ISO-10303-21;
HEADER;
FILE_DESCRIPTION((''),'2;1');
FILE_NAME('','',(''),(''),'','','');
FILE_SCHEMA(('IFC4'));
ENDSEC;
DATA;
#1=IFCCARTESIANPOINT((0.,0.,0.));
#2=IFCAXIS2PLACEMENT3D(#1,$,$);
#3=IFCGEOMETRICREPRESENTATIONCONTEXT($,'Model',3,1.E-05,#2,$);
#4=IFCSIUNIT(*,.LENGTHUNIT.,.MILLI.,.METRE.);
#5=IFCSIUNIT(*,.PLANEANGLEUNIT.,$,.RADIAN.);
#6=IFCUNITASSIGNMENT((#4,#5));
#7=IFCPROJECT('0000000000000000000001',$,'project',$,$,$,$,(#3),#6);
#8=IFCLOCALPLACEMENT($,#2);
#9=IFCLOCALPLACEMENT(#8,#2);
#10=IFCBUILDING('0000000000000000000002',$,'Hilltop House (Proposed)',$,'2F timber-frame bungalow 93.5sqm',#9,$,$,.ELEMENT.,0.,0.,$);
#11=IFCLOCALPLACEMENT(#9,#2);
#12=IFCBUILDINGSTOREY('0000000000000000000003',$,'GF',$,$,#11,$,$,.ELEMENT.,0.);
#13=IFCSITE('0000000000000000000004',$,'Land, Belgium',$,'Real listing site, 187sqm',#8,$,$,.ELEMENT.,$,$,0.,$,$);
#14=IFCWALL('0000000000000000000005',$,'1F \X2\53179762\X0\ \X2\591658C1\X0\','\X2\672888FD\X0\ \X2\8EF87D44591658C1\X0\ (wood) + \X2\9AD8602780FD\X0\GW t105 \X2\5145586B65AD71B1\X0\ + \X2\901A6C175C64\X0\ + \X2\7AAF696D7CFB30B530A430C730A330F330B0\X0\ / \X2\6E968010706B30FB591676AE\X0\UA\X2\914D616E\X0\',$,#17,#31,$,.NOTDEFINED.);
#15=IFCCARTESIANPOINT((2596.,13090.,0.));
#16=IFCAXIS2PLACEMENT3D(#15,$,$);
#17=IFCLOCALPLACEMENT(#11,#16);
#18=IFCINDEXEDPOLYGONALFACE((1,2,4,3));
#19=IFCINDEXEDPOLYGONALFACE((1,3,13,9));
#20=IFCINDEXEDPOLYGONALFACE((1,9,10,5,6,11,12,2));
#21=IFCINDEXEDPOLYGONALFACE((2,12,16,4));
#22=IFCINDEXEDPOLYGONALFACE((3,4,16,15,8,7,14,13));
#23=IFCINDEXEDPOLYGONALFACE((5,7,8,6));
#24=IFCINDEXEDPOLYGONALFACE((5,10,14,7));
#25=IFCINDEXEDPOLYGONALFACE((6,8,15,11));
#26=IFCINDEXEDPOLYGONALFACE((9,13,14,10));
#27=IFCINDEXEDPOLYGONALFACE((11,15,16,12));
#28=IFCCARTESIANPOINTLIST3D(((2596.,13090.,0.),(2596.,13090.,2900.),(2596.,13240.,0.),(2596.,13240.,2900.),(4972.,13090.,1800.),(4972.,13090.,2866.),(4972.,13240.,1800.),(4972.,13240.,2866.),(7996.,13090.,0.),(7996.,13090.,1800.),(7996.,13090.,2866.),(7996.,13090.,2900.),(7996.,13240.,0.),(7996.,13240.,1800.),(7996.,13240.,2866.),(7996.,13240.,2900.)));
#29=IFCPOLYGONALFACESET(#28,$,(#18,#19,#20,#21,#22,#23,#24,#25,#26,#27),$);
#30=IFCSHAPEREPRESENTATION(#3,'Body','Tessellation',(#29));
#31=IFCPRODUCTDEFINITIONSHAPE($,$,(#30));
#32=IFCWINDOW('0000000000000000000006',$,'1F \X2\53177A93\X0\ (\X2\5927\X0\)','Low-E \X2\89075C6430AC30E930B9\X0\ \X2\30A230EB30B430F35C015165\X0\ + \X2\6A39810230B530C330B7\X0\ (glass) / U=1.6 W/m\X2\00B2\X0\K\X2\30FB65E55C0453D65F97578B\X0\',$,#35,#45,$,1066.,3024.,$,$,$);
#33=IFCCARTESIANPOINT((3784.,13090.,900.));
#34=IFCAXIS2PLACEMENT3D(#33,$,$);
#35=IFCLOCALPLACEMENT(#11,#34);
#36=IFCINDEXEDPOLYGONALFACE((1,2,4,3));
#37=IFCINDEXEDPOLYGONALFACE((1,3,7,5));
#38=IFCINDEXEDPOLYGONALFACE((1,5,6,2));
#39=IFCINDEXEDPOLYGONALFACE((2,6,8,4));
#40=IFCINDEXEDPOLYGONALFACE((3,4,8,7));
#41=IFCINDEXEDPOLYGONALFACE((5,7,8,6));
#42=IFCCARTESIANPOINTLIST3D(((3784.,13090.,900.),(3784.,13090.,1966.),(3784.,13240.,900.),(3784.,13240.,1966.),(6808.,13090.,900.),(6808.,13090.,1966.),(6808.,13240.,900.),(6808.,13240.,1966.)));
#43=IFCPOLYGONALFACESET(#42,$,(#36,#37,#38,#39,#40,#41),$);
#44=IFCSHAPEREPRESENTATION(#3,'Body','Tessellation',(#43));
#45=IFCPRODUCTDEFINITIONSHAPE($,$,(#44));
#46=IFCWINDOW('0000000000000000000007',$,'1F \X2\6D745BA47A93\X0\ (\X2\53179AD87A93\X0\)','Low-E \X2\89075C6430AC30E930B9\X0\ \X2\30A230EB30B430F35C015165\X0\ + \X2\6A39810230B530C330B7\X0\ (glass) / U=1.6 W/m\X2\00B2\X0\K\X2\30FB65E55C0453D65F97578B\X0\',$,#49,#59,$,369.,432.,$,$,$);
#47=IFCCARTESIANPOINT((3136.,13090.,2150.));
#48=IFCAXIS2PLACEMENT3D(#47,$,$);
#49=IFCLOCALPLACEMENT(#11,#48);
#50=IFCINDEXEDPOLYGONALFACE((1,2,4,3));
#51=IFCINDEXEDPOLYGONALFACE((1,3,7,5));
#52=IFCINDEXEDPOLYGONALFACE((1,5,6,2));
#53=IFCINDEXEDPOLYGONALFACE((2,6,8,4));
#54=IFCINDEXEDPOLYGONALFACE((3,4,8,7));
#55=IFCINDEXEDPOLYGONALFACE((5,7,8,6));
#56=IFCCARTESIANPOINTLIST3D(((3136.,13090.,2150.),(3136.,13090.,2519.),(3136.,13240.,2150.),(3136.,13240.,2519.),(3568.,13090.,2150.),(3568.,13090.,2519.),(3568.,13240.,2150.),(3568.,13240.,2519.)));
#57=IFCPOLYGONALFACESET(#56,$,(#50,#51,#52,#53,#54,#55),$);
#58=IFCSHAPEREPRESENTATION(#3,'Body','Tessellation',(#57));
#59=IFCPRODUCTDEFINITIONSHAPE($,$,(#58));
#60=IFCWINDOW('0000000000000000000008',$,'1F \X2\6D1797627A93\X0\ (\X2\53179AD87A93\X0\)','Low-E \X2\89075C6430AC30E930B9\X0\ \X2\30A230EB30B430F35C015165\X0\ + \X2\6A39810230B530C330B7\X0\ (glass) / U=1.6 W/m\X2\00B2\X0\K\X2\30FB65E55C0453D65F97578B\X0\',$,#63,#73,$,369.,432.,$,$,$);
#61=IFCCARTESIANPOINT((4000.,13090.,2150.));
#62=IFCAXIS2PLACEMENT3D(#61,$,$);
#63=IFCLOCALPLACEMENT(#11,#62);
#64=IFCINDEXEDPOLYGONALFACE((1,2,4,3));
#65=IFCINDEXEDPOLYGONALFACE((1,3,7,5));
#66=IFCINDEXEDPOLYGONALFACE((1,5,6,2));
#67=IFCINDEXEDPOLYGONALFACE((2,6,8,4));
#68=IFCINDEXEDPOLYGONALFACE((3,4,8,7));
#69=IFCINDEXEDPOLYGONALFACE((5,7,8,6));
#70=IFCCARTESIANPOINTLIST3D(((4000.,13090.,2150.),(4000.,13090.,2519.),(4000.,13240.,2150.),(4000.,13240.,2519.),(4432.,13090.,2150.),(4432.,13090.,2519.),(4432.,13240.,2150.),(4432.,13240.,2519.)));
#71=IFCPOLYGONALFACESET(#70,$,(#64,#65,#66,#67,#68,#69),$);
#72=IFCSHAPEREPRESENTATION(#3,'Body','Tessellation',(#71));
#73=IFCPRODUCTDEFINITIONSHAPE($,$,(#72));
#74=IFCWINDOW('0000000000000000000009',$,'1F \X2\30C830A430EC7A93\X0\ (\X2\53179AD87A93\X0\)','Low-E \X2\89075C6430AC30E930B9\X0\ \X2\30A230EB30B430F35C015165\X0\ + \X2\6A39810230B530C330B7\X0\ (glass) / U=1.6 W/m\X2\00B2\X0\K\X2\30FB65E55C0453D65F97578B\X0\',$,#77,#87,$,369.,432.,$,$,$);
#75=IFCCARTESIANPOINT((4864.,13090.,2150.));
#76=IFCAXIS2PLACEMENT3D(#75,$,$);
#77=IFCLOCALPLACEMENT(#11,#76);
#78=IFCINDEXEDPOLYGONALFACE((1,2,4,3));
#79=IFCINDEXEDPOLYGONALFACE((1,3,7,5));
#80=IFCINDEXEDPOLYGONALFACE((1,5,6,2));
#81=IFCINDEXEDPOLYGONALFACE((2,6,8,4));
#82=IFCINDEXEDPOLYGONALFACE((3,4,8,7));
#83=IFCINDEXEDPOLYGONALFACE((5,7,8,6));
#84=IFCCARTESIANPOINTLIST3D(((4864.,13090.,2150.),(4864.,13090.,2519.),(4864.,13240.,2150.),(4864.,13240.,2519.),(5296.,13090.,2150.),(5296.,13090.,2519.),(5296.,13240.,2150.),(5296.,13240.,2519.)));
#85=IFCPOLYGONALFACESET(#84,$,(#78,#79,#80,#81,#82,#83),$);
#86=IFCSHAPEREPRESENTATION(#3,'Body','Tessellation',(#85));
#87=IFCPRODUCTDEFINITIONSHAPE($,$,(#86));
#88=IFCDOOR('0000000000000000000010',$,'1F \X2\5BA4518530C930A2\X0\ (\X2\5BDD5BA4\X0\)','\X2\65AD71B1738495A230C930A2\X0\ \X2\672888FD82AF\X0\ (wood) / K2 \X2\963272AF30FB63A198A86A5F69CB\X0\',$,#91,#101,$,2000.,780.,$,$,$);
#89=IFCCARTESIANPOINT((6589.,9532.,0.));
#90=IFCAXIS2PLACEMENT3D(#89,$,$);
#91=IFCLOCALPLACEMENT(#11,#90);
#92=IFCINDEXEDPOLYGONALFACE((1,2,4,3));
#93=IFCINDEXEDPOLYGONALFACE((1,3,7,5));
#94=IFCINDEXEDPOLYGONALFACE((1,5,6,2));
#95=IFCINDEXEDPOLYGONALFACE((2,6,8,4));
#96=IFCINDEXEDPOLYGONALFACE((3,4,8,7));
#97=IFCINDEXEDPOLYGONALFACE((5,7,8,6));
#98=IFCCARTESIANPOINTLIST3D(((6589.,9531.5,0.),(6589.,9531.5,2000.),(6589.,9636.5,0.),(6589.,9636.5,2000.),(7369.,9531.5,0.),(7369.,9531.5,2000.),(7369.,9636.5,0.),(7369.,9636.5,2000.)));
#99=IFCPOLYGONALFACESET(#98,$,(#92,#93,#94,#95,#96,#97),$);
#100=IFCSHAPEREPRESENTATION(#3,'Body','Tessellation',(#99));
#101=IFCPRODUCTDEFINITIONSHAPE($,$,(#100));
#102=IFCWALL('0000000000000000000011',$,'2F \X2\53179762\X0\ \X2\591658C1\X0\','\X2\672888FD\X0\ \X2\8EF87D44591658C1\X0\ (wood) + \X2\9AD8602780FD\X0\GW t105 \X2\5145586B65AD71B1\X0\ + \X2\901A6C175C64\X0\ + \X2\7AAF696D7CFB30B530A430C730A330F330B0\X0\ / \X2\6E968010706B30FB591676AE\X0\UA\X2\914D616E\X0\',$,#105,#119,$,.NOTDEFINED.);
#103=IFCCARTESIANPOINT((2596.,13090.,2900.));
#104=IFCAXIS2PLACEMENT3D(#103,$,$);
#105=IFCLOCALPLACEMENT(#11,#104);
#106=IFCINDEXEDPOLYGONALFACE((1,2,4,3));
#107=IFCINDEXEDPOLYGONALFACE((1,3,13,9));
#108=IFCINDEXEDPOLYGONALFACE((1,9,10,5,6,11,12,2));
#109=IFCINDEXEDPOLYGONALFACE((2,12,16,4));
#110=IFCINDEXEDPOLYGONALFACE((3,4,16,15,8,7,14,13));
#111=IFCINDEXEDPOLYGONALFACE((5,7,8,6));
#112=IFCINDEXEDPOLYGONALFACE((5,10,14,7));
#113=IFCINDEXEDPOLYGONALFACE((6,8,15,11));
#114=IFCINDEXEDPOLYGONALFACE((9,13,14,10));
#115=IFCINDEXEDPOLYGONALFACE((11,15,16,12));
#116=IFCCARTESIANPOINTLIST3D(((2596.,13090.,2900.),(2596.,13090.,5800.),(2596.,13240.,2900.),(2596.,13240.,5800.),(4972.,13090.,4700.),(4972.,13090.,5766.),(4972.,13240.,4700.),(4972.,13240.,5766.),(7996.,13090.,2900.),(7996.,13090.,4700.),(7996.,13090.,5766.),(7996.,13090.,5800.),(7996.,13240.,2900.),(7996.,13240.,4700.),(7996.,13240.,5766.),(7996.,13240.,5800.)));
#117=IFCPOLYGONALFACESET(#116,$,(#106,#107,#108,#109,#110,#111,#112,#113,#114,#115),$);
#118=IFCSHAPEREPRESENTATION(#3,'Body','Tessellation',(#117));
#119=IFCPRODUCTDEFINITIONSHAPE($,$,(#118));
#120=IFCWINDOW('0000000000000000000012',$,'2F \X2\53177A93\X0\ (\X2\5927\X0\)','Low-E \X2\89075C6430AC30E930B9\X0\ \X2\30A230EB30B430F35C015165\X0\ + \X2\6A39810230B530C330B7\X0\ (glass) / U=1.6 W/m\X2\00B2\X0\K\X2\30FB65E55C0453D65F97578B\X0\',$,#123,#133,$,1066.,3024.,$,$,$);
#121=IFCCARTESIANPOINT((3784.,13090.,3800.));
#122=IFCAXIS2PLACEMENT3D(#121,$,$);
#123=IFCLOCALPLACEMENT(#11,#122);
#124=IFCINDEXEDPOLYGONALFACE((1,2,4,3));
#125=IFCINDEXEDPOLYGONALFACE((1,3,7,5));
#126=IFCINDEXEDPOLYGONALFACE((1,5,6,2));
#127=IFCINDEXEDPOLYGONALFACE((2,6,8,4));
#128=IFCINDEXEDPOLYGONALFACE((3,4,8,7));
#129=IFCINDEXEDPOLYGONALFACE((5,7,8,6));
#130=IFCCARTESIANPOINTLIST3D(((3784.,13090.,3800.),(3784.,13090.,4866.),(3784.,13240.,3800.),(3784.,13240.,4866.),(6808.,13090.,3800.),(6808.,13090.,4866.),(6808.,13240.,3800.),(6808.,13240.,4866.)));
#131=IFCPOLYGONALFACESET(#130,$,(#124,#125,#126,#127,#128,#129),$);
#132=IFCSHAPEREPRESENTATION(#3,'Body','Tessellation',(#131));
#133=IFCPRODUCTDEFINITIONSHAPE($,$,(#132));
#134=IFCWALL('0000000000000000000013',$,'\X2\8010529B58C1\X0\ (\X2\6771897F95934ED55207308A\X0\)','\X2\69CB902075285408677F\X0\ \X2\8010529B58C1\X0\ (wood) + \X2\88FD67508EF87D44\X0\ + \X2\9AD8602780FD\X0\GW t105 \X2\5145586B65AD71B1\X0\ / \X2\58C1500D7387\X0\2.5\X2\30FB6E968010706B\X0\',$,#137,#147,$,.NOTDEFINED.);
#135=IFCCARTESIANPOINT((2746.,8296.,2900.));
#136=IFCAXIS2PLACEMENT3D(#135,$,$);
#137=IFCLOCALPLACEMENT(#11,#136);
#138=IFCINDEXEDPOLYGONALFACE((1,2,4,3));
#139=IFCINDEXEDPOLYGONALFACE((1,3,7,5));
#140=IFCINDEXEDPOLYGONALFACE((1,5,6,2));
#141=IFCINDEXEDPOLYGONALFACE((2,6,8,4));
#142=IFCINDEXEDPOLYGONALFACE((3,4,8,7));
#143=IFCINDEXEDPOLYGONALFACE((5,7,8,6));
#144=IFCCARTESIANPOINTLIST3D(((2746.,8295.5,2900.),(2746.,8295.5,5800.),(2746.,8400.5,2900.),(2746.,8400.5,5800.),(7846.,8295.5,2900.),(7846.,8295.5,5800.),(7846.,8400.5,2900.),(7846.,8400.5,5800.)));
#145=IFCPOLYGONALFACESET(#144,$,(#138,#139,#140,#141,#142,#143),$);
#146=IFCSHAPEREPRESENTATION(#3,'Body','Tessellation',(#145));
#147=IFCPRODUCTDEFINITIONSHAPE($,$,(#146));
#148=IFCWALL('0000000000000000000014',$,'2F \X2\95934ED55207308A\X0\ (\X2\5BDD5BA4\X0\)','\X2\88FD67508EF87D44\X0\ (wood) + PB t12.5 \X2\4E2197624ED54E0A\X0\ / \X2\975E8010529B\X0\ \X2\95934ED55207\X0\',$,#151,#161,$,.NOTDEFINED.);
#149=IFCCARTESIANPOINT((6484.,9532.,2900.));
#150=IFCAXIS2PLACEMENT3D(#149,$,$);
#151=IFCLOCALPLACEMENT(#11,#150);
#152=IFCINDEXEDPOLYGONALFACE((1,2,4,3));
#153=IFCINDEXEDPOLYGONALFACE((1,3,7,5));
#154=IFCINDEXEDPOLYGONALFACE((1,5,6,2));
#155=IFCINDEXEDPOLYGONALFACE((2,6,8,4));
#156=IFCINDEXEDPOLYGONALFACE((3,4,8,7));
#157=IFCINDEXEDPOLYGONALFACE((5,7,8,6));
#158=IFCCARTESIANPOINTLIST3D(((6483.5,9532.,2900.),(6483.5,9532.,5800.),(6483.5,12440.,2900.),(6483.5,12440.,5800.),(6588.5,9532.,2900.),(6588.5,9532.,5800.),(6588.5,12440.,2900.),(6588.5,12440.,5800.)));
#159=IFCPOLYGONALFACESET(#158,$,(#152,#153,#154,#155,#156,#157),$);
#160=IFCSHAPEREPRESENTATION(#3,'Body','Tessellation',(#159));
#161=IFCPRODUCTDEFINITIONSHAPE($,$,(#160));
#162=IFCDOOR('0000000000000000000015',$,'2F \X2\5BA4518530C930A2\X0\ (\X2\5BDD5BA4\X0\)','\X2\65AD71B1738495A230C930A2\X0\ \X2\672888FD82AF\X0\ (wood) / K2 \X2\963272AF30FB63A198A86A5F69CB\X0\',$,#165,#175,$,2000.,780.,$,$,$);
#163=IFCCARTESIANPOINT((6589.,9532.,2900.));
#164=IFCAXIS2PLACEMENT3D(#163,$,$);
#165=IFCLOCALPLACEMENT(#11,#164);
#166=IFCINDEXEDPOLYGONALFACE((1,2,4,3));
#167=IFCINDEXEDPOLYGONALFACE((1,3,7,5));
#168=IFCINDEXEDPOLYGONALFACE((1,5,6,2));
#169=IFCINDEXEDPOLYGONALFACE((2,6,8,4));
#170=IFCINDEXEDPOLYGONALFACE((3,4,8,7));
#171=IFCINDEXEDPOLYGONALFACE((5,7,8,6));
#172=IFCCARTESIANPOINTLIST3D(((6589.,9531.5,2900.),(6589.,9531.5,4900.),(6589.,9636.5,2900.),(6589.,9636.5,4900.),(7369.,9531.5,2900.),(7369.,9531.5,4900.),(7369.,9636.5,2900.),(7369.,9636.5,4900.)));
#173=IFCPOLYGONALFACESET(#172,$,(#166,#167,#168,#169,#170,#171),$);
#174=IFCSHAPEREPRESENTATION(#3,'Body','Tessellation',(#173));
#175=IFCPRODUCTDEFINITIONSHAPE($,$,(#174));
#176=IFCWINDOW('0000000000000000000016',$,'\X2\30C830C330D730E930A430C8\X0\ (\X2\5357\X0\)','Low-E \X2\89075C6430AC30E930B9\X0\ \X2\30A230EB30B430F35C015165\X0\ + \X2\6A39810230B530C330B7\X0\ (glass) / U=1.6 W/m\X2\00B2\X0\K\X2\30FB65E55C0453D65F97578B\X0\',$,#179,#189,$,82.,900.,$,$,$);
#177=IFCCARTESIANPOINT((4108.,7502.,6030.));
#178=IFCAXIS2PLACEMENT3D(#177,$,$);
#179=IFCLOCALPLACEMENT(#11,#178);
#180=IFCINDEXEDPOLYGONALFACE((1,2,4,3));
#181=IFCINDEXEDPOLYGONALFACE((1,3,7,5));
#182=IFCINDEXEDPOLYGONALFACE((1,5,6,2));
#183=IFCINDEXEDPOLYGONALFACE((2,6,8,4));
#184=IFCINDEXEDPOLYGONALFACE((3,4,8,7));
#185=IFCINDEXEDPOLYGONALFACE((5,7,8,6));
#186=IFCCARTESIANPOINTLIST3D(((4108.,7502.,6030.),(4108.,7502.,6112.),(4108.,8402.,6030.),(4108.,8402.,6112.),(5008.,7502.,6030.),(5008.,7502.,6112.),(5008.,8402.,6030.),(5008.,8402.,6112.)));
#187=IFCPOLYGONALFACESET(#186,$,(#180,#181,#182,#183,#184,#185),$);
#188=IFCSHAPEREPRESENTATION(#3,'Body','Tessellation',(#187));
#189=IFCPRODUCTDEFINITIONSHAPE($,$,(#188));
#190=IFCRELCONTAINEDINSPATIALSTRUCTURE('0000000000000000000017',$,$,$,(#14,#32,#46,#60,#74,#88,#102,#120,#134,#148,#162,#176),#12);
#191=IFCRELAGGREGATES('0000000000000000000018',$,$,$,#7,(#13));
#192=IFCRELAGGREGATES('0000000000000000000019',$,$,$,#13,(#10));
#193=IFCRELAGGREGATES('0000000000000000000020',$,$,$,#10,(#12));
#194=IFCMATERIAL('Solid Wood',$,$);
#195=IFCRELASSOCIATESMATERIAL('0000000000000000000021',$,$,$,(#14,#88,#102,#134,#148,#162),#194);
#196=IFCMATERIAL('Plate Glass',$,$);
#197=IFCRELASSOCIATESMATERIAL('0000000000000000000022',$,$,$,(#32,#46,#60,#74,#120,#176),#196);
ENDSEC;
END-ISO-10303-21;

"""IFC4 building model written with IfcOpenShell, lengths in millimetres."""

from ifc_helpers import new_model, si_unit, frame, frame_2d, origin, place, context, project, spatial, rectangle, extrude, material, element, fill, save


model = new_model("IFC4")

# Units and contexts
model_context = context("Model", 3, precision=1e-05, world=origin())
ifc_project = project(units=[si_unit("LENGTHUNIT", "METRE", prefix="MILLI"), si_unit("PLANEANGLEUNIT", "RADIAN")], contexts=[model_context])

# Site, building, storey
site_placement = place(None, origin())
site = spatial("IfcSite", under=ifc_project, at=site_placement, Name="Land, Belgium", ObjectType="Real listing site, 187sqm", CompositionType="ELEMENT", RefElevation=0.0)
building_placement = place(site_placement, origin())
building = spatial("IfcBuilding", under=site, at=building_placement, Name="Hilltop House (Proposed)", ObjectType="2F timber-frame bungalow 93.5sqm", CompositionType="ELEMENT", ElevationOfRefHeight=0.0, ElevationOfTerrain=0.0)
storey_placement = place(building_placement, origin())
storey = spatial("IfcBuildingStorey", under=building, at=storey_placement, Name="GF", CompositionType="ELEMENT", Elevation=0.0)

# Wall, openings, windows
ifc_material_1 = material(Name="Solid Wood")
wall_1_placement = place(storey_placement, frame((2596.0, 13090.0, 0.0)))
wall_1 = element("IfcWall", 1, at=wall_1_placement, inside=storey, material=ifc_material_1, Name="1F 北面 外壁", Description="木製 軸組外壁 (wood) + 高性能GW t105 充填断熱 + 通気層 + 窯業系サイディング / 準耐火・外皮UA配慮", PredefinedType="NOTDEFINED", context=model_context, shape_type="SweptSolid", body=[
    extrude(rectangle(XDim=5400.0, YDim=150.0, at=frame_2d((2700.0, 75.0))), frame((2596.0, 13090.0, 0.0)), (0.0, 0.0, 1.0), 2900.0),
])
opening_1_placement = place(storey_placement, frame((3784.0, 13090.0, 900.0)))
opening_1 = element("IfcOpeningElement", 2, at=opening_1_placement, cuts=wall_1, PredefinedType="NOTDEFINED", context=model_context, shape_type="SweptSolid", body=[
    extrude(rectangle(XDim=3024.0, YDim=150.0, at=frame_2d((1512.0, 75.0))), frame((3784.0, 13090.0, 900.0)), (0.0, 0.0, 1.0), 1066.0),
])
opening_2_placement = place(storey_placement, frame((3136.0, 13090.0, 2150.0)))
opening_2 = element("IfcOpeningElement", 3, at=opening_2_placement, cuts=wall_1, PredefinedType="NOTDEFINED", context=model_context, shape_type="SweptSolid", body=[
    extrude(rectangle(XDim=432.0, YDim=150.0, at=frame_2d((216.0, 75.0))), frame((3136.0, 13090.0, 2150.0)), (0.0, 0.0, 1.0), 369.0),
])
opening_3_placement = place(storey_placement, frame((4000.0, 13090.0, 2150.0)))
opening_3 = element("IfcOpeningElement", 4, at=opening_3_placement, cuts=wall_1, PredefinedType="NOTDEFINED", context=model_context, shape_type="SweptSolid", body=[
    extrude(rectangle(XDim=432.0, YDim=150.0, at=frame_2d((216.0, 75.0))), frame((4000.0, 13090.0, 2150.0)), (0.0, 0.0, 1.0), 369.0),
])
opening_4_placement = place(storey_placement, frame((4864.0, 13090.0, 2150.0)))
opening_4 = element("IfcOpeningElement", 5, at=opening_4_placement, cuts=wall_1, PredefinedType="NOTDEFINED", context=model_context, shape_type="SweptSolid", body=[
    extrude(rectangle(XDim=432.0, YDim=150.0, at=frame_2d((216.0, 75.0))), frame((4864.0, 13090.0, 2150.0)), (0.0, 0.0, 1.0), 369.0),
])
ifc_material_2 = material(Name="Plate Glass")
window_1_placement = place(storey_placement, frame((3784.0, 13090.0, 900.0)))
window_1 = element("IfcWindow", 6, at=window_1_placement, inside=storey, material=ifc_material_2, Name="1F 北窓 (大)", Description="Low-E 複層ガラス アルゴン封入 + 樹脂サッシ (glass) / U=1.6 W/m²K・日射取得型", OverallHeight=1066.0, OverallWidth=3024.0, context=model_context, shape_type="SweptSolid", body=[
    extrude(rectangle(XDim=3024.0, YDim=150.0, at=frame_2d((1512.0, 75.0))), frame((3784.0, 13090.0, 900.0)), (0.0, 0.0, 1.0), 1066.0),
])
fill(opening_1, window_1)
window_2_placement = place(storey_placement, frame((3136.0, 13090.0, 2150.0)))
window_2 = element("IfcWindow", 7, at=window_2_placement, inside=storey, material=ifc_material_2, Name="1F 浴室窓 (北高窓)", Description="Low-E 複層ガラス アルゴン封入 + 樹脂サッシ (glass) / U=1.6 W/m²K・日射取得型", OverallHeight=369.0, OverallWidth=432.0, context=model_context, shape_type="SweptSolid", body=[
    extrude(rectangle(XDim=432.0, YDim=150.0, at=frame_2d((216.0, 75.0))), frame((3136.0, 13090.0, 2150.0)), (0.0, 0.0, 1.0), 369.0),
])
fill(opening_2, window_2)
window_3_placement = place(storey_placement, frame((4000.0, 13090.0, 2150.0)))
window_3 = element("IfcWindow", 8, at=window_3_placement, inside=storey, material=ifc_material_2, Name="1F 洗面窓 (北高窓)", Description="Low-E 複層ガラス アルゴン封入 + 樹脂サッシ (glass) / U=1.6 W/m²K・日射取得型", OverallHeight=369.0, OverallWidth=432.0, context=model_context, shape_type="SweptSolid", body=[
    extrude(rectangle(XDim=432.0, YDim=150.0, at=frame_2d((216.0, 75.0))), frame((4000.0, 13090.0, 2150.0)), (0.0, 0.0, 1.0), 369.0),
])
fill(opening_3, window_3)
window_4_placement = place(storey_placement, frame((4864.0, 13090.0, 2150.0)))
window_4 = element("IfcWindow", 9, at=window_4_placement, inside=storey, material=ifc_material_2, Name="1F トイレ窓 (北高窓)", Description="Low-E 複層ガラス アルゴン封入 + 樹脂サッシ (glass) / U=1.6 W/m²K・日射取得型", OverallHeight=369.0, OverallWidth=432.0, context=model_context, shape_type="SweptSolid", body=[
    extrude(rectangle(XDim=432.0, YDim=150.0, at=frame_2d((216.0, 75.0))), frame((4864.0, 13090.0, 2150.0)), (0.0, 0.0, 1.0), 369.0),
])
fill(opening_4, window_4)

# Door
door_1_placement = place(storey_placement, frame((6589.0, 9532.0, 0.0)))
element("IfcDoor", 10, at=door_1_placement, inside=storey, material=ifc_material_1, Name="1F 室内ドア (寝室)", Description="断熱玄関ドア 木製芯 (wood) / K2 防犯・採風機構", OverallHeight=2000.0, OverallWidth=780.0, context=model_context, shape_type="SweptSolid", body=[
    extrude(rectangle(XDim=780.0, YDim=105.0, at=frame_2d((390.0, 52.0))), frame((6589.0, 9532.0, 0.0)), (0.0, 0.0, 1.0), 2000.0),
])

# Wall, opening, window
wall_2_placement = place(storey_placement, frame((2596.0, 13090.0, 2900.0)))
wall_2 = element("IfcWall", 11, at=wall_2_placement, inside=storey, material=ifc_material_1, Name="2F 北面 外壁", Description="木製 軸組外壁 (wood) + 高性能GW t105 充填断熱 + 通気層 + 窯業系サイディング / 準耐火・外皮UA配慮", PredefinedType="NOTDEFINED", context=model_context, shape_type="SweptSolid", body=[
    extrude(rectangle(XDim=5400.0, YDim=150.0, at=frame_2d((2700.0, 75.0))), frame((2596.0, 13090.0, 2900.0)), (0.0, 0.0, 1.0), 2900.0),
])
opening_5_placement = place(storey_placement, frame((3784.0, 13090.0, 3800.0)))
opening_5 = element("IfcOpeningElement", 12, at=opening_5_placement, cuts=wall_2, PredefinedType="NOTDEFINED", context=model_context, shape_type="SweptSolid", body=[
    extrude(rectangle(XDim=3024.0, YDim=150.0, at=frame_2d((1512.0, 75.0))), frame((3784.0, 13090.0, 3800.0)), (0.0, 0.0, 1.0), 1066.0),
])
window_5_placement = place(storey_placement, frame((3784.0, 13090.0, 3800.0)))
window_5 = element("IfcWindow", 13, at=window_5_placement, inside=storey, material=ifc_material_2, Name="2F 北窓 (大)", Description="Low-E 複層ガラス アルゴン封入 + 樹脂サッシ (glass) / U=1.6 W/m²K・日射取得型", OverallHeight=1066.0, OverallWidth=3024.0, context=model_context, shape_type="SweptSolid", body=[
    extrude(rectangle(XDim=3024.0, YDim=150.0, at=frame_2d((1512.0, 75.0))), frame((3784.0, 13090.0, 3800.0)), (0.0, 0.0, 1.0), 1066.0),
])
fill(opening_5, window_5)

# Walls
wall_3_placement = place(storey_placement, frame((2746.0, 8296.0, 2900.0)))
element("IfcWall", 14, at=wall_3_placement, inside=storey, material=ifc_material_1, Name="耐力壁 (東西間仕切り)", Description="構造用合板 耐力壁 (wood) + 製材軸組 + 高性能GW t105 充填断熱 / 壁倍率2.5・準耐火", PredefinedType="NOTDEFINED", context=model_context, shape_type="SweptSolid", body=[
    extrude(rectangle(XDim=5100.0, YDim=105.0, at=frame_2d((2550.0, 52.0))), frame((2746.0, 8296.0, 2900.0)), (0.0, 0.0, 1.0), 2900.0),
])
wall_4_placement = place(storey_placement, frame((6484.0, 9532.0, 2900.0)))
element("IfcWall", 15, at=wall_4_placement, inside=storey, material=ifc_material_1, Name="2F 間仕切り (寝室)", Description="製材軸組 (wood) + PB t12.5 両面仕上 / 非耐力 間仕切", PredefinedType="NOTDEFINED", context=model_context, shape_type="SweptSolid", body=[
    extrude(rectangle(XDim=105.0, YDim=2908.0, at=frame_2d((52.0, 1454.0))), frame((6484.0, 9532.0, 2900.0)), (0.0, 0.0, 1.0), 2900.0),
])

# Door
door_2_placement = place(storey_placement, frame((6589.0, 9532.0, 2900.0)))
element("IfcDoor", 16, at=door_2_placement, inside=storey, material=ifc_material_1, Name="2F 室内ドア (寝室)", Description="断熱玄関ドア 木製芯 (wood) / K2 防犯・採風機構", OverallHeight=2000.0, OverallWidth=780.0, context=model_context, shape_type="SweptSolid", body=[
    extrude(rectangle(XDim=780.0, YDim=105.0, at=frame_2d((390.0, 52.0))), frame((6589.0, 9532.0, 2900.0)), (0.0, 0.0, 1.0), 2000.0),
])

# Window
window_6_placement = place(storey_placement, frame((4108.0, 7502.0, 6030.0)))
element("IfcWindow", 17, at=window_6_placement, inside=storey, material=ifc_material_2, Name="トップライト (南)", Description="Low-E 複層ガラス アルゴン封入 + 樹脂サッシ (glass) / U=1.6 W/m²K・日射取得型", OverallHeight=82.0, OverallWidth=900.0, context=model_context, shape_type="SweptSolid", body=[
    extrude(rectangle(XDim=900.0, YDim=900.0, at=frame_2d((450.0, 450.0))), frame((4108.0, 7502.0, 6030.0)), (0.0, 0.0, 1.0), 82.0),
])

save(model, "model.ifc")
